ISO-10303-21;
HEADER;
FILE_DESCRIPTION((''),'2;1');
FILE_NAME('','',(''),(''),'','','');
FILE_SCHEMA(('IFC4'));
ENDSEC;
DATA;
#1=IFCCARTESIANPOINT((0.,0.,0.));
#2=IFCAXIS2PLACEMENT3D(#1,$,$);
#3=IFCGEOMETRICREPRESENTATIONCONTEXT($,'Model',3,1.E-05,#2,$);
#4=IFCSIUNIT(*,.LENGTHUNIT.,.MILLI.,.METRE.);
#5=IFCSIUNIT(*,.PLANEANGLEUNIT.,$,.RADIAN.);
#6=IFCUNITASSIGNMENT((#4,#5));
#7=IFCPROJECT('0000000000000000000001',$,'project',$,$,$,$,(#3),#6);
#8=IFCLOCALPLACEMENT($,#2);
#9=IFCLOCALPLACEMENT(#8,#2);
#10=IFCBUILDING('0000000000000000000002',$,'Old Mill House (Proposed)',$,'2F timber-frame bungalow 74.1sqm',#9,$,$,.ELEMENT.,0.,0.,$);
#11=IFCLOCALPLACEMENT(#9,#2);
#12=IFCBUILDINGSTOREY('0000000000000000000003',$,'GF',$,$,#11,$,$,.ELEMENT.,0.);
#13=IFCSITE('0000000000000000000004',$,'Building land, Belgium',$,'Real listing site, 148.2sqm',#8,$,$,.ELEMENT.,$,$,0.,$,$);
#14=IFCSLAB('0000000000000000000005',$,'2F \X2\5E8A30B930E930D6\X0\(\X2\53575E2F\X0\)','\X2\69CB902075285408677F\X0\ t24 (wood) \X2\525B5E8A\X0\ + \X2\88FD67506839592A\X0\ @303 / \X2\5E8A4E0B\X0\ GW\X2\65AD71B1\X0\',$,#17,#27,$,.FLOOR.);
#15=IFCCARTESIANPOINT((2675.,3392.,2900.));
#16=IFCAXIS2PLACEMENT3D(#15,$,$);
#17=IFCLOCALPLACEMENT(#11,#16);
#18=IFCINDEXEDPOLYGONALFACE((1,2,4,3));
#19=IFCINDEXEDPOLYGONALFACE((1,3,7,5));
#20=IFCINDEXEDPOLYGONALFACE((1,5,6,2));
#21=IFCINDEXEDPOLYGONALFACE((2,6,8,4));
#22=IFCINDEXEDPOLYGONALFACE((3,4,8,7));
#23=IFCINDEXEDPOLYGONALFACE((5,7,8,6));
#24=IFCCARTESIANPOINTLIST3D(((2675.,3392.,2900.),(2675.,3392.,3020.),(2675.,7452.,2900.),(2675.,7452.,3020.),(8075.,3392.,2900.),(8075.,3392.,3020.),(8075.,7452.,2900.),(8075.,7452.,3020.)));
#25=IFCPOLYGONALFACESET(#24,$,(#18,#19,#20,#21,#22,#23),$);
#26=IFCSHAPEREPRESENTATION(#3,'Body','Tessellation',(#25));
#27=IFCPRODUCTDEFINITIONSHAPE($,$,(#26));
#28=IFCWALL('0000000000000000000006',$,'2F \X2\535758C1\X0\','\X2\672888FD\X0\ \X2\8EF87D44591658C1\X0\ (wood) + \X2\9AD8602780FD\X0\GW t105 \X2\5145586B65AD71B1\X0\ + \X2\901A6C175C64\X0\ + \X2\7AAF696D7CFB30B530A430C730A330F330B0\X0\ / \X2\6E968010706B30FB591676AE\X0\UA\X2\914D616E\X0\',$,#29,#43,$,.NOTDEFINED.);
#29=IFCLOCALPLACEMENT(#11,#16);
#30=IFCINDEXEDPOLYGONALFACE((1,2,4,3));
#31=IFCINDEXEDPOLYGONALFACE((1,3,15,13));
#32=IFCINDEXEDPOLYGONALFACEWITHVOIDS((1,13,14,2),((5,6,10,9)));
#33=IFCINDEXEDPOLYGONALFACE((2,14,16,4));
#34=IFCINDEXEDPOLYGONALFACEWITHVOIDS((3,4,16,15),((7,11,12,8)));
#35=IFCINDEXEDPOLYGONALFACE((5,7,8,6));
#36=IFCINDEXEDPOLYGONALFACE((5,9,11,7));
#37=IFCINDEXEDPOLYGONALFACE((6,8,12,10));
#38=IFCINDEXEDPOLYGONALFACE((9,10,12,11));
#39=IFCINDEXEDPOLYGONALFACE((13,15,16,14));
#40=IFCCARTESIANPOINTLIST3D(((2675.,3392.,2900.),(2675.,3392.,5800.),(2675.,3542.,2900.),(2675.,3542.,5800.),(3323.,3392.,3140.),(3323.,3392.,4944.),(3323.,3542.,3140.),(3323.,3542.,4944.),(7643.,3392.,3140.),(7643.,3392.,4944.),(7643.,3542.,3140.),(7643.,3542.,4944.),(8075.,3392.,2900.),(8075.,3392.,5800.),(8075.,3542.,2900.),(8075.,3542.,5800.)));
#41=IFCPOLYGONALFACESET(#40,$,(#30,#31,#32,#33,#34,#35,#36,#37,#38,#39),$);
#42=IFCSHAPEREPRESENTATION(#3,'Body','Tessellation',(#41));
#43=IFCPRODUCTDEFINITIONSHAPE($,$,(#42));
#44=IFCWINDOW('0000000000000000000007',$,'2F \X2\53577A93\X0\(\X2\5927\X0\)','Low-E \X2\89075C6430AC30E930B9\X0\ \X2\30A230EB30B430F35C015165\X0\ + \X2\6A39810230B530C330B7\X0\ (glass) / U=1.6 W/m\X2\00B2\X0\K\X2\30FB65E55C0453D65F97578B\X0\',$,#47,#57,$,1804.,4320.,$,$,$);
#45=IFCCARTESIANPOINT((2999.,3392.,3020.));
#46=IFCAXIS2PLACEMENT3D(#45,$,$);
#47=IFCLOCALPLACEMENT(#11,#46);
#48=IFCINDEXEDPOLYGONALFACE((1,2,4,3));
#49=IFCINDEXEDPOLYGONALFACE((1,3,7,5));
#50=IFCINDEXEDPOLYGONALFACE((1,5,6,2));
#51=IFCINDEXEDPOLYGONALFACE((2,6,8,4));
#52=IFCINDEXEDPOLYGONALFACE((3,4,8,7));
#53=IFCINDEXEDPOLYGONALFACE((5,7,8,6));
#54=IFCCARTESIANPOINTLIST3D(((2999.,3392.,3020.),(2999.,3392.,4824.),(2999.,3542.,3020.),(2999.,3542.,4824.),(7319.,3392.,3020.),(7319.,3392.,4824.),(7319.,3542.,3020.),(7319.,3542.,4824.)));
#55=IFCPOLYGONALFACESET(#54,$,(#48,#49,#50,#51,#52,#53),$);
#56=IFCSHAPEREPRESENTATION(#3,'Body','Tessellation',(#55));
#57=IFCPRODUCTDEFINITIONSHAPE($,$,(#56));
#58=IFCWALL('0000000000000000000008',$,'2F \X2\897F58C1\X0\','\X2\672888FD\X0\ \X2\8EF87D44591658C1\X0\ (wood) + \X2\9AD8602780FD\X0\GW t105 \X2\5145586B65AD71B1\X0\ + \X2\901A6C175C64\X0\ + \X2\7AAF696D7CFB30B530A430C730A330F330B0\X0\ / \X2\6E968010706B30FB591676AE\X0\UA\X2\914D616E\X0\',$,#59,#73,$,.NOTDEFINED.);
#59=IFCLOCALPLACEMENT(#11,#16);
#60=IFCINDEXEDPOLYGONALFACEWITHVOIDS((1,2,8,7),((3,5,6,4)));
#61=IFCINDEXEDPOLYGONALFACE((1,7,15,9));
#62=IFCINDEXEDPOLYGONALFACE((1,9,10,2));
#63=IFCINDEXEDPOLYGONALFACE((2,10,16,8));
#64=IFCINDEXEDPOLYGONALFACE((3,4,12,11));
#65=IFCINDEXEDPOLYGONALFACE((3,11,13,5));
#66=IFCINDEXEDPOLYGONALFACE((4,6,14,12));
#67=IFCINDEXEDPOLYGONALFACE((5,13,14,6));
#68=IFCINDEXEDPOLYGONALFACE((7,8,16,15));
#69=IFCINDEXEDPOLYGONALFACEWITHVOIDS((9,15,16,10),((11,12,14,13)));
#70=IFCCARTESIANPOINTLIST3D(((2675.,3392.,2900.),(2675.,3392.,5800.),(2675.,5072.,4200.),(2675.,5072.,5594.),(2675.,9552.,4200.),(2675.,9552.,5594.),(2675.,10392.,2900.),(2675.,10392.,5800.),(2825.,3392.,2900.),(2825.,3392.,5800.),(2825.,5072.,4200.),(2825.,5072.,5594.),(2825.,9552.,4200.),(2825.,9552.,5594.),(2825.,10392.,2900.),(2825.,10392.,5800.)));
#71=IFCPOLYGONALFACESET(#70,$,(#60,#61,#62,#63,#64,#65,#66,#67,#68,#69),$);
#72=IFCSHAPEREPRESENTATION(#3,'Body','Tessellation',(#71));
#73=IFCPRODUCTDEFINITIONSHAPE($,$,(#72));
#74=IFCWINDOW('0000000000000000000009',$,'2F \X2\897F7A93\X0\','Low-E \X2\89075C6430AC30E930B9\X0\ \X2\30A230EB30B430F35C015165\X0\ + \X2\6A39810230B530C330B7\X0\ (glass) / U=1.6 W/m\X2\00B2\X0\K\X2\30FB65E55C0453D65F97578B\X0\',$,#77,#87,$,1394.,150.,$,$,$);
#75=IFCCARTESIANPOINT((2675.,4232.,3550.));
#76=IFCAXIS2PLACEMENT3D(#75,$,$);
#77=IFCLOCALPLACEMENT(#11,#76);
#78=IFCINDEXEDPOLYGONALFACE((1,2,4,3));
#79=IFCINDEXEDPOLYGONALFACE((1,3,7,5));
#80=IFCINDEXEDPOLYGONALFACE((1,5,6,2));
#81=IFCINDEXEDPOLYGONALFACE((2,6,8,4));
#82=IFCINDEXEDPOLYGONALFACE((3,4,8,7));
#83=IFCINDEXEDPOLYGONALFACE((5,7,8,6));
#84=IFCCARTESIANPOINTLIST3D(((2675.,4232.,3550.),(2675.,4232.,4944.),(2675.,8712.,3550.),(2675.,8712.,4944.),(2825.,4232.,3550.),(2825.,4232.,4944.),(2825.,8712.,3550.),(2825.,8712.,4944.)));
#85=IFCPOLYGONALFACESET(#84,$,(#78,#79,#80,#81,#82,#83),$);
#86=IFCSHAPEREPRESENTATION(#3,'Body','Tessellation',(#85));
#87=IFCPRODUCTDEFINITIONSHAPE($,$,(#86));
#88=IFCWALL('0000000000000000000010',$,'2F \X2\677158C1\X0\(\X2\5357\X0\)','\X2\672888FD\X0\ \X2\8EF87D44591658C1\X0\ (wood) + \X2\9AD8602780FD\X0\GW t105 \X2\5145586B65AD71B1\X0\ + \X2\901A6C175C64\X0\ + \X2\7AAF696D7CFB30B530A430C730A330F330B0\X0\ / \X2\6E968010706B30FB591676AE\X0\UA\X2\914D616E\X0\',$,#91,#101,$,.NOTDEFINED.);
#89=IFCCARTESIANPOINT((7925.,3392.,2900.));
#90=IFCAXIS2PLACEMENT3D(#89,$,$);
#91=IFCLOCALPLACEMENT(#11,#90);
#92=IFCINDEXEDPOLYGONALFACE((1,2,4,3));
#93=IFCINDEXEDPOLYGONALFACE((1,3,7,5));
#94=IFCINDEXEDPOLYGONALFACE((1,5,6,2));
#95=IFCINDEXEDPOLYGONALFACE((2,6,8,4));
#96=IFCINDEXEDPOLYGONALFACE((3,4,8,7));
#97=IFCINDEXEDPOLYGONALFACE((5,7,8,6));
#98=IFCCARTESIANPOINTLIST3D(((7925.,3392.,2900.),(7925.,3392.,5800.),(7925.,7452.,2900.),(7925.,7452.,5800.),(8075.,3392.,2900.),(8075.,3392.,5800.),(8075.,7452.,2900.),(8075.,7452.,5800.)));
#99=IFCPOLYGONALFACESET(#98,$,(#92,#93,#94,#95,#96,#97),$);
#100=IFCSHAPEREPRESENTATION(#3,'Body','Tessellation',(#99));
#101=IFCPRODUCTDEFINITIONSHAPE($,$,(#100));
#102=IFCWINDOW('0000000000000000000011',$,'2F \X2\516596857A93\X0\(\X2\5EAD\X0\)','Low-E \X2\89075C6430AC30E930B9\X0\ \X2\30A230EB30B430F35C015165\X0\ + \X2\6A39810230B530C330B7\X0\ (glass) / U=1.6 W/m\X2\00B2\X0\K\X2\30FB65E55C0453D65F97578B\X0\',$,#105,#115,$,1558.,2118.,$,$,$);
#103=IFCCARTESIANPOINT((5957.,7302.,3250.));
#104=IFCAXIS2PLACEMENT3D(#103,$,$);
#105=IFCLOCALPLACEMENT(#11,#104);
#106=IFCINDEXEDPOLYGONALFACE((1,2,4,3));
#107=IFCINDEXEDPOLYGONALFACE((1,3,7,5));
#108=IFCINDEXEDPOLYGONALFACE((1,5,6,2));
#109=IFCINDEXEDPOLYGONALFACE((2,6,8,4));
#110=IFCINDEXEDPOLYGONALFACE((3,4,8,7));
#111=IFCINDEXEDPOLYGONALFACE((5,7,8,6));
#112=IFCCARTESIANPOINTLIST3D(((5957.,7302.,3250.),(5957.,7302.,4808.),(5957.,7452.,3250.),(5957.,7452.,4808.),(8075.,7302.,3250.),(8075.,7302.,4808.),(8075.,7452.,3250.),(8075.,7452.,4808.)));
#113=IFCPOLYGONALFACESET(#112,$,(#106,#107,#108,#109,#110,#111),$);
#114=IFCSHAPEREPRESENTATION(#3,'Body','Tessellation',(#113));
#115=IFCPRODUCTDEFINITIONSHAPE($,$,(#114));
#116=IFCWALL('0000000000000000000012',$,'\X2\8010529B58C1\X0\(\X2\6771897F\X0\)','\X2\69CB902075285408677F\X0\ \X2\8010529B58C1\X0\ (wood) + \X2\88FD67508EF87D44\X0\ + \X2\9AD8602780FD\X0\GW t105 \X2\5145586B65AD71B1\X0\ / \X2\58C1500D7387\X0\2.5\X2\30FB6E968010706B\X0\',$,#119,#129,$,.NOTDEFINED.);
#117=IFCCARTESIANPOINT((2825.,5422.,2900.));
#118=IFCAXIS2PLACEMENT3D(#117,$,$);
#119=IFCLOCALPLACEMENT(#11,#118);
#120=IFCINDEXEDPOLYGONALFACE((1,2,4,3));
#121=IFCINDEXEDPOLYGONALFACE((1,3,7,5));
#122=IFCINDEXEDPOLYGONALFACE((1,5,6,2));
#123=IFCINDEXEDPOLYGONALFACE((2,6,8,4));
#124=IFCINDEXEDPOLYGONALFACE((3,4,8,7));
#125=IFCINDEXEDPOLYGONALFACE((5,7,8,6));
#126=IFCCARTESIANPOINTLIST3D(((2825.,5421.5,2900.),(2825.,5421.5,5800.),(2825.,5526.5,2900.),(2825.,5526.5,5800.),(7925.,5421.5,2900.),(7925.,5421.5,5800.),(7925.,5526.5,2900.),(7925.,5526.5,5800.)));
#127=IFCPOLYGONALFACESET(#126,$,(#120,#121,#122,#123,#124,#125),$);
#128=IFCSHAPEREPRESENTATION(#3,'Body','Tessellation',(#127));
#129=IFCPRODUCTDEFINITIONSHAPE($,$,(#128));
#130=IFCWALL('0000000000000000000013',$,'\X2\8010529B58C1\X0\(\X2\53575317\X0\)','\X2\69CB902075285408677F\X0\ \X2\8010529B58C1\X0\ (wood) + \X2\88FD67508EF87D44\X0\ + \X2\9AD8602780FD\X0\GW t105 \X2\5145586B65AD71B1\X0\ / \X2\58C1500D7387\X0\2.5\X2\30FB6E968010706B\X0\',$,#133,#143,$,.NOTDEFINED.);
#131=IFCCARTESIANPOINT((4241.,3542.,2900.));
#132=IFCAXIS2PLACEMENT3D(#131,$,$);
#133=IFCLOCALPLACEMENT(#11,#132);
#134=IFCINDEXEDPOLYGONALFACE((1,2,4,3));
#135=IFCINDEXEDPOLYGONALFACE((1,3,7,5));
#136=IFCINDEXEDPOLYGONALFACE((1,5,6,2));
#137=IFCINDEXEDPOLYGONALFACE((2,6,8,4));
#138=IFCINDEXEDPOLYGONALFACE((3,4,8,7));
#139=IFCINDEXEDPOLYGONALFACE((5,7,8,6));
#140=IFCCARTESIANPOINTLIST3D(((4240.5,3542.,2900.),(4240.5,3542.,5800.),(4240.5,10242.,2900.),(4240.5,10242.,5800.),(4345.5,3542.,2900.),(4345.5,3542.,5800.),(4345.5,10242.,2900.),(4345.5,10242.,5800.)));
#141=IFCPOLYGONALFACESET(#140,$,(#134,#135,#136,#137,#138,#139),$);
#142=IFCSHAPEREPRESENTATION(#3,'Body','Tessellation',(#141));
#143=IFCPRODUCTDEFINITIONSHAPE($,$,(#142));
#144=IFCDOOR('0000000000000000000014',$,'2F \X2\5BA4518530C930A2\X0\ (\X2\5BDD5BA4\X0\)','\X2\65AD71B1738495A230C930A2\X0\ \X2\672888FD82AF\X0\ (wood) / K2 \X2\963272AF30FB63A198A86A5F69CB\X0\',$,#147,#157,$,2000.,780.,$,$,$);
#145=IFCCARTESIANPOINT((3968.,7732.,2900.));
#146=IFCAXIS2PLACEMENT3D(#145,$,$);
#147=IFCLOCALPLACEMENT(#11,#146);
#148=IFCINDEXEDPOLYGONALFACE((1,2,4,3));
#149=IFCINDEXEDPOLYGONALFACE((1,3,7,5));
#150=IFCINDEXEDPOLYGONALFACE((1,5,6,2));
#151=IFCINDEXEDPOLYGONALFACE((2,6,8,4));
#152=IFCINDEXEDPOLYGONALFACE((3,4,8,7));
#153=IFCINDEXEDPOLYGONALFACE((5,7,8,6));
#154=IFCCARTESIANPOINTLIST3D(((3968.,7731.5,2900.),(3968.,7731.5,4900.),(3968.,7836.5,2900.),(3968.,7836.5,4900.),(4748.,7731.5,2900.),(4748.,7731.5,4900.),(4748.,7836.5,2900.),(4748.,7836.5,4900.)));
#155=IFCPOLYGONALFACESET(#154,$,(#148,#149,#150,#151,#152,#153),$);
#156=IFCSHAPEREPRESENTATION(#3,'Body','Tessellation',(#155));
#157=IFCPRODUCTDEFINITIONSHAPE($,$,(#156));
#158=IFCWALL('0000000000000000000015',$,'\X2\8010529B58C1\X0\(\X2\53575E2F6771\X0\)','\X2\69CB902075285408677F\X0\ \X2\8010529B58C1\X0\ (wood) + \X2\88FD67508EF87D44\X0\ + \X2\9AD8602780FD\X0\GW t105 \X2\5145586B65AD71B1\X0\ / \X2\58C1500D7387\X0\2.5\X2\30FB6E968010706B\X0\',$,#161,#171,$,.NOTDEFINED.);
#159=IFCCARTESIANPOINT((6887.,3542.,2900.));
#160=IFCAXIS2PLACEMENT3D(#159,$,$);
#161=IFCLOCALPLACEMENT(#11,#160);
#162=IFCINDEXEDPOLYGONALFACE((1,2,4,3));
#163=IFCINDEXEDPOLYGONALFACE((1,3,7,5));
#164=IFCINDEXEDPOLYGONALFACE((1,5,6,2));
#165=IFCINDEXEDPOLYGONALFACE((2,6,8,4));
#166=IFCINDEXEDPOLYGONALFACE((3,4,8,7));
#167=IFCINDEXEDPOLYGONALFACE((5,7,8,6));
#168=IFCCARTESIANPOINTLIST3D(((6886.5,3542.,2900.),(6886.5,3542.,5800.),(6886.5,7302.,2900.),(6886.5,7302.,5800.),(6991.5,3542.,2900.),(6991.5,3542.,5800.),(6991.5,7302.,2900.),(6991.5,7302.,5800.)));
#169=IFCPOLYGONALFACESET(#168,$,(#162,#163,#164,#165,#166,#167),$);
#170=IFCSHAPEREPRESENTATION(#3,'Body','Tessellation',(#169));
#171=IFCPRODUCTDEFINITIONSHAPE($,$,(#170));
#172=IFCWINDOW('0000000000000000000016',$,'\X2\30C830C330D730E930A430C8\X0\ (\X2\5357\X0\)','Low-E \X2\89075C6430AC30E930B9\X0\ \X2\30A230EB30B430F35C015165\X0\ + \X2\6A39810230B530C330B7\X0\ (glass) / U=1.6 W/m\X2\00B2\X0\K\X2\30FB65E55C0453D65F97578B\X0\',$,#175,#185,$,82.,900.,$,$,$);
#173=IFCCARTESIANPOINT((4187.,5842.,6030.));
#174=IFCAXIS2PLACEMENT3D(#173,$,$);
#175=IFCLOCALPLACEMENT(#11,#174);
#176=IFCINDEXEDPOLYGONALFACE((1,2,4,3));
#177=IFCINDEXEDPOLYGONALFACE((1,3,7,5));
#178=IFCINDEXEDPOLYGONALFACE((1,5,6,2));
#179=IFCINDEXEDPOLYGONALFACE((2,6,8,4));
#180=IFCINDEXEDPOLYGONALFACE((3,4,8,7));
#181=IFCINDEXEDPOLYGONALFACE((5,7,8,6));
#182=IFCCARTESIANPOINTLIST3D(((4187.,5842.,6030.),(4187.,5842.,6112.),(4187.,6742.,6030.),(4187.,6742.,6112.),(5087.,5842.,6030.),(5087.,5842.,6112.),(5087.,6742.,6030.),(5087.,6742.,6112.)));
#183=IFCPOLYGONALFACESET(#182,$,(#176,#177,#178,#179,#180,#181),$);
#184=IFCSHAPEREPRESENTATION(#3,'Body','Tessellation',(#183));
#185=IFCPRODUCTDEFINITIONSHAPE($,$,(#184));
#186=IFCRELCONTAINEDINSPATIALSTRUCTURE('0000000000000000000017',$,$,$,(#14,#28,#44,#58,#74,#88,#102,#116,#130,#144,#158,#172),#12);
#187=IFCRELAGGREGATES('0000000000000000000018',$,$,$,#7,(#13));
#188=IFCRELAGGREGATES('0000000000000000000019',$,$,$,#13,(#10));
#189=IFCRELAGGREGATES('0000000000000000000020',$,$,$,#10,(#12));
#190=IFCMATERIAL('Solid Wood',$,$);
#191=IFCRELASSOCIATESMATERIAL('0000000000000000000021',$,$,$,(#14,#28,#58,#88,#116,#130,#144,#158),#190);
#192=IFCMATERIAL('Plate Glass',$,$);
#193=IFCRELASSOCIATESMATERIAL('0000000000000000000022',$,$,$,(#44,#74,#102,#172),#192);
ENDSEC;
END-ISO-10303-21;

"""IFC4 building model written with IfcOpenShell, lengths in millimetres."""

from ifc_helpers import new_model, si_unit, frame, frame_2d, origin, place, context, project, spatial, rectangle, extrude, material, element, fill, save


model = new_model("IFC4")

# Units and contexts
model_context = context("Model", 3, precision=1e-05, world=origin())
ifc_project = project(units=[si_unit("LENGTHUNIT", "METRE", prefix="MILLI"), si_unit("PLANEANGLEUNIT", "RADIAN")], contexts=[model_context])

# Site, building, storey
site_placement = place(None, origin())
site = spatial("IfcSite", under=ifc_project, at=site_placement, Name="Building land, Belgium", ObjectType="Real listing site, 148.2sqm", CompositionType="ELEMENT", RefElevation=0.0)
building_placement = place(site_placement, origin())
building = spatial("IfcBuilding", under=site, at=building_placement, Name="Old Mill House (Proposed)", ObjectType="2F timber-frame bungalow 74.1sqm", CompositionType="ELEMENT", ElevationOfRefHeight=0.0, ElevationOfTerrain=0.0)
storey_placement = place(building_placement, origin())
storey = spatial("IfcBuildingStorey", under=building, at=storey_placement, Name="GF", CompositionType="ELEMENT", Elevation=0.0)

# Slab
ifc_material_1 = material(Name="Solid Wood")
slab_placement = place(storey_placement, frame((2675.0, 3392.0, 2900.0)))
element("IfcSlab", 1, at=slab_placement, inside=storey, material=ifc_material_1, Name="2F 床スラブ(南帯)", Description="構造用合板 t24 (wood) 剛床 + 製材根太 @303 / 床下 GW断熱", PredefinedType="FLOOR", context=model_context, shape_type="SweptSolid", body=[
    extrude(rectangle(XDim=5400.0, YDim=4060.0, at=frame_2d((2700.0, 2030.0))), frame((2675.0, 3392.0, 2900.0)), (0.0, 0.0, 1.0), 120.0),
])

# Walls, openings, windows
wall_1_placement = place(storey_placement, frame((2675.0, 3392.0, 2900.0)))
wall_1 = element("IfcWall", 2, at=wall_1_placement, inside=storey, material=ifc_material_1, Name="2F 南壁", Description="木製 軸組外壁 (wood) + 高性能GW t105 充填断熱 + 通気層 + 窯業系サイディング / 準耐火・外皮UA配慮", PredefinedType="NOTDEFINED", context=model_context, shape_type="SweptSolid", body=[
    extrude(rectangle(XDim=5400.0, YDim=150.0, at=frame_2d((2700.0, 75.0))), frame((2675.0, 3392.0, 2900.0)), (0.0, 0.0, 1.0), 2900.0),
])
opening_1_placement = place(storey_placement, frame((2999.0, 3392.0, 3020.0)))
opening_1 = element("IfcOpeningElement", 3, at=opening_1_placement, cuts=wall_1, PredefinedType="NOTDEFINED", context=model_context, shape_type="SweptSolid", body=[
    extrude(rectangle(XDim=4320.0, YDim=150.0, at=frame_2d((2160.0, 75.0))), frame((2999.0, 3392.0, 3020.0)), (0.0, 0.0, 1.0), 1804.0),
])
ifc_material_2 = material(Name="Plate Glass")
window_1_placement = place(storey_placement, frame((2999.0, 3392.0, 3020.0)))
window_1 = element("IfcWindow", 4, at=window_1_placement, inside=storey, material=ifc_material_2, Name="2F 南窓(大)", Description="Low-E 複層ガラス アルゴン封入 + 樹脂サッシ (glass) / U=1.6 W/m²K・日射取得型", OverallHeight=1804.0, OverallWidth=4320.0, context=model_context, shape_type="SweptSolid", body=[
    extrude(rectangle(XDim=4320.0, YDim=150.0, at=frame_2d((2160.0, 75.0))), frame((2999.0, 3392.0, 3020.0)), (0.0, 0.0, 1.0), 1804.0),
])
fill(opening_1, window_1)
wall_2_placement = place(storey_placement, frame((2675.0, 3392.0, 2900.0)))
wall_2 = element("IfcWall", 5, at=wall_2_placement, inside=storey, material=ifc_material_1, Name="2F 西壁", Description="木製 軸組外壁 (wood) + 高性能GW t105 充填断熱 + 通気層 + 窯業系サイディング / 準耐火・外皮UA配慮", PredefinedType="NOTDEFINED", context=model_context, shape_type="SweptSolid", body=[
    extrude(rectangle(XDim=150.0, YDim=7000.0, at=frame_2d((75.0, 3500.0))), frame((2675.0, 3392.0, 2900.0)), (0.0, 0.0, 1.0), 2900.0),
])
opening_2_placement = place(storey_placement, frame((2675.0, 4232.0, 3550.0)))
opening_2 = element("IfcOpeningElement", 6, at=opening_2_placement, cuts=wall_2, PredefinedType="NOTDEFINED", context=model_context, shape_type="SweptSolid", body=[
    extrude(rectangle(XDim=150.0, YDim=4480.0, at=frame_2d((75.0, 2240.0))), frame((2675.0, 4232.0, 3550.0)), (0.0, 0.0, 1.0), 1394.0),
])
window_2_placement = place(storey_placement, frame((2675.0, 4232.0, 3550.0)))
window_2 = element("IfcWindow", 7, at=window_2_placement, inside=storey, material=ifc_material_2, Name="2F 西窓", Description="Low-E 複層ガラス アルゴン封入 + 樹脂サッシ (glass) / U=1.6 W/m²K・日射取得型", OverallHeight=1394.0, OverallWidth=150.0, context=model_context, shape_type="SweptSolid", body=[
    extrude(rectangle(XDim=150.0, YDim=4480.0, at=frame_2d((75.0, 2240.0))), frame((2675.0, 4232.0, 3550.0)), (0.0, 0.0, 1.0), 1394.0),
])
fill(opening_2, window_2)
wall_3_placement = place(storey_placement, frame((7925.0, 3392.0, 2900.0)))
wall_3 = element("IfcWall", 8, at=wall_3_placement, inside=storey, material=ifc_material_1, Name="2F 東壁(南)", Description="木製 軸組外壁 (wood) + 高性能GW t105 充填断熱 + 通気層 + 窯業系サイディング / 準耐火・外皮UA配慮", PredefinedType="NOTDEFINED", context=model_context, shape_type="SweptSolid", body=[
    extrude(rectangle(XDim=150.0, YDim=4060.0, at=frame_2d((75.0, 2030.0))), frame((7925.0, 3392.0, 2900.0)), (0.0, 0.0, 1.0), 2900.0),
])
opening_3_placement = place(storey_placement, frame((5957.0, 7302.0, 3250.0)))
opening_3 = element("IfcOpeningElement", 9, at=opening_3_placement, cuts=wall_3, PredefinedType="NOTDEFINED", context=model_context, shape_type="SweptSolid", body=[
    extrude(rectangle(XDim=2118.0, YDim=150.0, at=frame_2d((1059.0, 75.0))), frame((5957.0, 7302.0, 3250.0)), (0.0, 0.0, 1.0), 1558.0),
])
window_3_placement = place(storey_placement, frame((5957.0, 7302.0, 3250.0)))
window_3 = element("IfcWindow", 10, at=window_3_placement, inside=storey, material=ifc_material_2, Name="2F 入隅窓(庭)", Description="Low-E 複層ガラス アルゴン封入 + 樹脂サッシ (glass) / U=1.6 W/m²K・日射取得型", OverallHeight=1558.0, OverallWidth=2118.0, context=model_context, shape_type="SweptSolid", body=[
    extrude(rectangle(XDim=2118.0, YDim=150.0, at=frame_2d((1059.0, 75.0))), frame((5957.0, 7302.0, 3250.0)), (0.0, 0.0, 1.0), 1558.0),
])
fill(opening_3, window_3)

# Wall
wall_4_placement = place(storey_placement, frame((2825.0, 5422.0, 2900.0)))
element("IfcWall", 11, at=wall_4_placement, inside=storey, material=ifc_material_1, Name="耐力壁(東西)", Description="構造用合板 耐力壁 (wood) + 製材軸組 + 高性能GW t105 充填断熱 / 壁倍率2.5・準耐火", PredefinedType="NOTDEFINED", context=model_context, shape_type="SweptSolid", body=[
    extrude(rectangle(XDim=5100.0, YDim=105.0, at=frame_2d((2550.0, 52.0))), frame((2825.0, 5422.0, 2900.0)), (0.0, 0.0, 1.0), 2900.0),
])

# Wall, opening, door
wall_5_placement = place(storey_placement, frame((4241.0, 3542.0, 2900.0)))
wall_5 = element("IfcWall", 12, at=wall_5_placement, inside=storey, material=ifc_material_1, Name="耐力壁(南北)", Description="構造用合板 耐力壁 (wood) + 製材軸組 + 高性能GW t105 充填断熱 / 壁倍率2.5・準耐火", PredefinedType="NOTDEFINED", context=model_context, shape_type="SweptSolid", body=[
    extrude(rectangle(XDim=105.0, YDim=6700.0, at=frame_2d((52.0, 3350.0))), frame((4241.0, 3542.0, 2900.0)), (0.0, 0.0, 1.0), 2900.0),
])
opening_4_placement = place(storey_placement, frame((3968.0, 7732.0, 2900.0)))
opening_4 = element("IfcOpeningElement", 13, at=opening_4_placement, cuts=wall_5, PredefinedType="NOTDEFINED", context=model_context, shape_type="SweptSolid", body=[
    extrude(rectangle(XDim=780.0, YDim=105.0, at=frame_2d((390.0, 52.0))), frame((3968.0, 7732.0, 2900.0)), (0.0, 0.0, 1.0), 2000.0),
])
door_placement = place(storey_placement, frame((3968.0, 7732.0, 2900.0)))
door = element("IfcDoor", 14, at=door_placement, inside=storey, material=ifc_material_1, Name="2F 室内ドア (寝室)", Description="断熱玄関ドア 木製芯 (wood) / K2 防犯・採風機構", OverallHeight=2000.0, OverallWidth=780.0, context=model_context, shape_type="SweptSolid", body=[
    extrude(rectangle(XDim=780.0, YDim=105.0, at=frame_2d((390.0, 52.0))), frame((3968.0, 7732.0, 2900.0)), (0.0, 0.0, 1.0), 2000.0),
])
fill(opening_4, door)

# Wall
wall_6_placement = place(storey_placement, frame((6887.0, 3542.0, 2900.0)))
element("IfcWall", 15, at=wall_6_placement, inside=storey, material=ifc_material_1, Name="耐力壁(南帯東)", Description="構造用合板 耐力壁 (wood) + 製材軸組 + 高性能GW t105 充填断熱 / 壁倍率2.5・準耐火", PredefinedType="NOTDEFINED", context=model_context, shape_type="SweptSolid", body=[
    extrude(rectangle(XDim=105.0, YDim=3760.0, at=frame_2d((52.0, 1880.0))), frame((6887.0, 3542.0, 2900.0)), (0.0, 0.0, 1.0), 2900.0),
])

# Window
window_4_placement = place(storey_placement, frame((4187.0, 5842.0, 6030.0)))
element("IfcWindow", 16, at=window_4_placement, inside=storey, material=ifc_material_2, Name="トップライト (南)", Description="Low-E 複層ガラス アルゴン封入 + 樹脂サッシ (glass) / U=1.6 W/m²K・日射取得型", OverallHeight=82.0, OverallWidth=900.0, context=model_context, shape_type="SweptSolid", body=[
    extrude(rectangle(XDim=900.0, YDim=900.0, at=frame_2d((450.0, 450.0))), frame((4187.0, 5842.0, 6030.0)), (0.0, 0.0, 1.0), 82.0),
])

save(model, "model.ifc")
